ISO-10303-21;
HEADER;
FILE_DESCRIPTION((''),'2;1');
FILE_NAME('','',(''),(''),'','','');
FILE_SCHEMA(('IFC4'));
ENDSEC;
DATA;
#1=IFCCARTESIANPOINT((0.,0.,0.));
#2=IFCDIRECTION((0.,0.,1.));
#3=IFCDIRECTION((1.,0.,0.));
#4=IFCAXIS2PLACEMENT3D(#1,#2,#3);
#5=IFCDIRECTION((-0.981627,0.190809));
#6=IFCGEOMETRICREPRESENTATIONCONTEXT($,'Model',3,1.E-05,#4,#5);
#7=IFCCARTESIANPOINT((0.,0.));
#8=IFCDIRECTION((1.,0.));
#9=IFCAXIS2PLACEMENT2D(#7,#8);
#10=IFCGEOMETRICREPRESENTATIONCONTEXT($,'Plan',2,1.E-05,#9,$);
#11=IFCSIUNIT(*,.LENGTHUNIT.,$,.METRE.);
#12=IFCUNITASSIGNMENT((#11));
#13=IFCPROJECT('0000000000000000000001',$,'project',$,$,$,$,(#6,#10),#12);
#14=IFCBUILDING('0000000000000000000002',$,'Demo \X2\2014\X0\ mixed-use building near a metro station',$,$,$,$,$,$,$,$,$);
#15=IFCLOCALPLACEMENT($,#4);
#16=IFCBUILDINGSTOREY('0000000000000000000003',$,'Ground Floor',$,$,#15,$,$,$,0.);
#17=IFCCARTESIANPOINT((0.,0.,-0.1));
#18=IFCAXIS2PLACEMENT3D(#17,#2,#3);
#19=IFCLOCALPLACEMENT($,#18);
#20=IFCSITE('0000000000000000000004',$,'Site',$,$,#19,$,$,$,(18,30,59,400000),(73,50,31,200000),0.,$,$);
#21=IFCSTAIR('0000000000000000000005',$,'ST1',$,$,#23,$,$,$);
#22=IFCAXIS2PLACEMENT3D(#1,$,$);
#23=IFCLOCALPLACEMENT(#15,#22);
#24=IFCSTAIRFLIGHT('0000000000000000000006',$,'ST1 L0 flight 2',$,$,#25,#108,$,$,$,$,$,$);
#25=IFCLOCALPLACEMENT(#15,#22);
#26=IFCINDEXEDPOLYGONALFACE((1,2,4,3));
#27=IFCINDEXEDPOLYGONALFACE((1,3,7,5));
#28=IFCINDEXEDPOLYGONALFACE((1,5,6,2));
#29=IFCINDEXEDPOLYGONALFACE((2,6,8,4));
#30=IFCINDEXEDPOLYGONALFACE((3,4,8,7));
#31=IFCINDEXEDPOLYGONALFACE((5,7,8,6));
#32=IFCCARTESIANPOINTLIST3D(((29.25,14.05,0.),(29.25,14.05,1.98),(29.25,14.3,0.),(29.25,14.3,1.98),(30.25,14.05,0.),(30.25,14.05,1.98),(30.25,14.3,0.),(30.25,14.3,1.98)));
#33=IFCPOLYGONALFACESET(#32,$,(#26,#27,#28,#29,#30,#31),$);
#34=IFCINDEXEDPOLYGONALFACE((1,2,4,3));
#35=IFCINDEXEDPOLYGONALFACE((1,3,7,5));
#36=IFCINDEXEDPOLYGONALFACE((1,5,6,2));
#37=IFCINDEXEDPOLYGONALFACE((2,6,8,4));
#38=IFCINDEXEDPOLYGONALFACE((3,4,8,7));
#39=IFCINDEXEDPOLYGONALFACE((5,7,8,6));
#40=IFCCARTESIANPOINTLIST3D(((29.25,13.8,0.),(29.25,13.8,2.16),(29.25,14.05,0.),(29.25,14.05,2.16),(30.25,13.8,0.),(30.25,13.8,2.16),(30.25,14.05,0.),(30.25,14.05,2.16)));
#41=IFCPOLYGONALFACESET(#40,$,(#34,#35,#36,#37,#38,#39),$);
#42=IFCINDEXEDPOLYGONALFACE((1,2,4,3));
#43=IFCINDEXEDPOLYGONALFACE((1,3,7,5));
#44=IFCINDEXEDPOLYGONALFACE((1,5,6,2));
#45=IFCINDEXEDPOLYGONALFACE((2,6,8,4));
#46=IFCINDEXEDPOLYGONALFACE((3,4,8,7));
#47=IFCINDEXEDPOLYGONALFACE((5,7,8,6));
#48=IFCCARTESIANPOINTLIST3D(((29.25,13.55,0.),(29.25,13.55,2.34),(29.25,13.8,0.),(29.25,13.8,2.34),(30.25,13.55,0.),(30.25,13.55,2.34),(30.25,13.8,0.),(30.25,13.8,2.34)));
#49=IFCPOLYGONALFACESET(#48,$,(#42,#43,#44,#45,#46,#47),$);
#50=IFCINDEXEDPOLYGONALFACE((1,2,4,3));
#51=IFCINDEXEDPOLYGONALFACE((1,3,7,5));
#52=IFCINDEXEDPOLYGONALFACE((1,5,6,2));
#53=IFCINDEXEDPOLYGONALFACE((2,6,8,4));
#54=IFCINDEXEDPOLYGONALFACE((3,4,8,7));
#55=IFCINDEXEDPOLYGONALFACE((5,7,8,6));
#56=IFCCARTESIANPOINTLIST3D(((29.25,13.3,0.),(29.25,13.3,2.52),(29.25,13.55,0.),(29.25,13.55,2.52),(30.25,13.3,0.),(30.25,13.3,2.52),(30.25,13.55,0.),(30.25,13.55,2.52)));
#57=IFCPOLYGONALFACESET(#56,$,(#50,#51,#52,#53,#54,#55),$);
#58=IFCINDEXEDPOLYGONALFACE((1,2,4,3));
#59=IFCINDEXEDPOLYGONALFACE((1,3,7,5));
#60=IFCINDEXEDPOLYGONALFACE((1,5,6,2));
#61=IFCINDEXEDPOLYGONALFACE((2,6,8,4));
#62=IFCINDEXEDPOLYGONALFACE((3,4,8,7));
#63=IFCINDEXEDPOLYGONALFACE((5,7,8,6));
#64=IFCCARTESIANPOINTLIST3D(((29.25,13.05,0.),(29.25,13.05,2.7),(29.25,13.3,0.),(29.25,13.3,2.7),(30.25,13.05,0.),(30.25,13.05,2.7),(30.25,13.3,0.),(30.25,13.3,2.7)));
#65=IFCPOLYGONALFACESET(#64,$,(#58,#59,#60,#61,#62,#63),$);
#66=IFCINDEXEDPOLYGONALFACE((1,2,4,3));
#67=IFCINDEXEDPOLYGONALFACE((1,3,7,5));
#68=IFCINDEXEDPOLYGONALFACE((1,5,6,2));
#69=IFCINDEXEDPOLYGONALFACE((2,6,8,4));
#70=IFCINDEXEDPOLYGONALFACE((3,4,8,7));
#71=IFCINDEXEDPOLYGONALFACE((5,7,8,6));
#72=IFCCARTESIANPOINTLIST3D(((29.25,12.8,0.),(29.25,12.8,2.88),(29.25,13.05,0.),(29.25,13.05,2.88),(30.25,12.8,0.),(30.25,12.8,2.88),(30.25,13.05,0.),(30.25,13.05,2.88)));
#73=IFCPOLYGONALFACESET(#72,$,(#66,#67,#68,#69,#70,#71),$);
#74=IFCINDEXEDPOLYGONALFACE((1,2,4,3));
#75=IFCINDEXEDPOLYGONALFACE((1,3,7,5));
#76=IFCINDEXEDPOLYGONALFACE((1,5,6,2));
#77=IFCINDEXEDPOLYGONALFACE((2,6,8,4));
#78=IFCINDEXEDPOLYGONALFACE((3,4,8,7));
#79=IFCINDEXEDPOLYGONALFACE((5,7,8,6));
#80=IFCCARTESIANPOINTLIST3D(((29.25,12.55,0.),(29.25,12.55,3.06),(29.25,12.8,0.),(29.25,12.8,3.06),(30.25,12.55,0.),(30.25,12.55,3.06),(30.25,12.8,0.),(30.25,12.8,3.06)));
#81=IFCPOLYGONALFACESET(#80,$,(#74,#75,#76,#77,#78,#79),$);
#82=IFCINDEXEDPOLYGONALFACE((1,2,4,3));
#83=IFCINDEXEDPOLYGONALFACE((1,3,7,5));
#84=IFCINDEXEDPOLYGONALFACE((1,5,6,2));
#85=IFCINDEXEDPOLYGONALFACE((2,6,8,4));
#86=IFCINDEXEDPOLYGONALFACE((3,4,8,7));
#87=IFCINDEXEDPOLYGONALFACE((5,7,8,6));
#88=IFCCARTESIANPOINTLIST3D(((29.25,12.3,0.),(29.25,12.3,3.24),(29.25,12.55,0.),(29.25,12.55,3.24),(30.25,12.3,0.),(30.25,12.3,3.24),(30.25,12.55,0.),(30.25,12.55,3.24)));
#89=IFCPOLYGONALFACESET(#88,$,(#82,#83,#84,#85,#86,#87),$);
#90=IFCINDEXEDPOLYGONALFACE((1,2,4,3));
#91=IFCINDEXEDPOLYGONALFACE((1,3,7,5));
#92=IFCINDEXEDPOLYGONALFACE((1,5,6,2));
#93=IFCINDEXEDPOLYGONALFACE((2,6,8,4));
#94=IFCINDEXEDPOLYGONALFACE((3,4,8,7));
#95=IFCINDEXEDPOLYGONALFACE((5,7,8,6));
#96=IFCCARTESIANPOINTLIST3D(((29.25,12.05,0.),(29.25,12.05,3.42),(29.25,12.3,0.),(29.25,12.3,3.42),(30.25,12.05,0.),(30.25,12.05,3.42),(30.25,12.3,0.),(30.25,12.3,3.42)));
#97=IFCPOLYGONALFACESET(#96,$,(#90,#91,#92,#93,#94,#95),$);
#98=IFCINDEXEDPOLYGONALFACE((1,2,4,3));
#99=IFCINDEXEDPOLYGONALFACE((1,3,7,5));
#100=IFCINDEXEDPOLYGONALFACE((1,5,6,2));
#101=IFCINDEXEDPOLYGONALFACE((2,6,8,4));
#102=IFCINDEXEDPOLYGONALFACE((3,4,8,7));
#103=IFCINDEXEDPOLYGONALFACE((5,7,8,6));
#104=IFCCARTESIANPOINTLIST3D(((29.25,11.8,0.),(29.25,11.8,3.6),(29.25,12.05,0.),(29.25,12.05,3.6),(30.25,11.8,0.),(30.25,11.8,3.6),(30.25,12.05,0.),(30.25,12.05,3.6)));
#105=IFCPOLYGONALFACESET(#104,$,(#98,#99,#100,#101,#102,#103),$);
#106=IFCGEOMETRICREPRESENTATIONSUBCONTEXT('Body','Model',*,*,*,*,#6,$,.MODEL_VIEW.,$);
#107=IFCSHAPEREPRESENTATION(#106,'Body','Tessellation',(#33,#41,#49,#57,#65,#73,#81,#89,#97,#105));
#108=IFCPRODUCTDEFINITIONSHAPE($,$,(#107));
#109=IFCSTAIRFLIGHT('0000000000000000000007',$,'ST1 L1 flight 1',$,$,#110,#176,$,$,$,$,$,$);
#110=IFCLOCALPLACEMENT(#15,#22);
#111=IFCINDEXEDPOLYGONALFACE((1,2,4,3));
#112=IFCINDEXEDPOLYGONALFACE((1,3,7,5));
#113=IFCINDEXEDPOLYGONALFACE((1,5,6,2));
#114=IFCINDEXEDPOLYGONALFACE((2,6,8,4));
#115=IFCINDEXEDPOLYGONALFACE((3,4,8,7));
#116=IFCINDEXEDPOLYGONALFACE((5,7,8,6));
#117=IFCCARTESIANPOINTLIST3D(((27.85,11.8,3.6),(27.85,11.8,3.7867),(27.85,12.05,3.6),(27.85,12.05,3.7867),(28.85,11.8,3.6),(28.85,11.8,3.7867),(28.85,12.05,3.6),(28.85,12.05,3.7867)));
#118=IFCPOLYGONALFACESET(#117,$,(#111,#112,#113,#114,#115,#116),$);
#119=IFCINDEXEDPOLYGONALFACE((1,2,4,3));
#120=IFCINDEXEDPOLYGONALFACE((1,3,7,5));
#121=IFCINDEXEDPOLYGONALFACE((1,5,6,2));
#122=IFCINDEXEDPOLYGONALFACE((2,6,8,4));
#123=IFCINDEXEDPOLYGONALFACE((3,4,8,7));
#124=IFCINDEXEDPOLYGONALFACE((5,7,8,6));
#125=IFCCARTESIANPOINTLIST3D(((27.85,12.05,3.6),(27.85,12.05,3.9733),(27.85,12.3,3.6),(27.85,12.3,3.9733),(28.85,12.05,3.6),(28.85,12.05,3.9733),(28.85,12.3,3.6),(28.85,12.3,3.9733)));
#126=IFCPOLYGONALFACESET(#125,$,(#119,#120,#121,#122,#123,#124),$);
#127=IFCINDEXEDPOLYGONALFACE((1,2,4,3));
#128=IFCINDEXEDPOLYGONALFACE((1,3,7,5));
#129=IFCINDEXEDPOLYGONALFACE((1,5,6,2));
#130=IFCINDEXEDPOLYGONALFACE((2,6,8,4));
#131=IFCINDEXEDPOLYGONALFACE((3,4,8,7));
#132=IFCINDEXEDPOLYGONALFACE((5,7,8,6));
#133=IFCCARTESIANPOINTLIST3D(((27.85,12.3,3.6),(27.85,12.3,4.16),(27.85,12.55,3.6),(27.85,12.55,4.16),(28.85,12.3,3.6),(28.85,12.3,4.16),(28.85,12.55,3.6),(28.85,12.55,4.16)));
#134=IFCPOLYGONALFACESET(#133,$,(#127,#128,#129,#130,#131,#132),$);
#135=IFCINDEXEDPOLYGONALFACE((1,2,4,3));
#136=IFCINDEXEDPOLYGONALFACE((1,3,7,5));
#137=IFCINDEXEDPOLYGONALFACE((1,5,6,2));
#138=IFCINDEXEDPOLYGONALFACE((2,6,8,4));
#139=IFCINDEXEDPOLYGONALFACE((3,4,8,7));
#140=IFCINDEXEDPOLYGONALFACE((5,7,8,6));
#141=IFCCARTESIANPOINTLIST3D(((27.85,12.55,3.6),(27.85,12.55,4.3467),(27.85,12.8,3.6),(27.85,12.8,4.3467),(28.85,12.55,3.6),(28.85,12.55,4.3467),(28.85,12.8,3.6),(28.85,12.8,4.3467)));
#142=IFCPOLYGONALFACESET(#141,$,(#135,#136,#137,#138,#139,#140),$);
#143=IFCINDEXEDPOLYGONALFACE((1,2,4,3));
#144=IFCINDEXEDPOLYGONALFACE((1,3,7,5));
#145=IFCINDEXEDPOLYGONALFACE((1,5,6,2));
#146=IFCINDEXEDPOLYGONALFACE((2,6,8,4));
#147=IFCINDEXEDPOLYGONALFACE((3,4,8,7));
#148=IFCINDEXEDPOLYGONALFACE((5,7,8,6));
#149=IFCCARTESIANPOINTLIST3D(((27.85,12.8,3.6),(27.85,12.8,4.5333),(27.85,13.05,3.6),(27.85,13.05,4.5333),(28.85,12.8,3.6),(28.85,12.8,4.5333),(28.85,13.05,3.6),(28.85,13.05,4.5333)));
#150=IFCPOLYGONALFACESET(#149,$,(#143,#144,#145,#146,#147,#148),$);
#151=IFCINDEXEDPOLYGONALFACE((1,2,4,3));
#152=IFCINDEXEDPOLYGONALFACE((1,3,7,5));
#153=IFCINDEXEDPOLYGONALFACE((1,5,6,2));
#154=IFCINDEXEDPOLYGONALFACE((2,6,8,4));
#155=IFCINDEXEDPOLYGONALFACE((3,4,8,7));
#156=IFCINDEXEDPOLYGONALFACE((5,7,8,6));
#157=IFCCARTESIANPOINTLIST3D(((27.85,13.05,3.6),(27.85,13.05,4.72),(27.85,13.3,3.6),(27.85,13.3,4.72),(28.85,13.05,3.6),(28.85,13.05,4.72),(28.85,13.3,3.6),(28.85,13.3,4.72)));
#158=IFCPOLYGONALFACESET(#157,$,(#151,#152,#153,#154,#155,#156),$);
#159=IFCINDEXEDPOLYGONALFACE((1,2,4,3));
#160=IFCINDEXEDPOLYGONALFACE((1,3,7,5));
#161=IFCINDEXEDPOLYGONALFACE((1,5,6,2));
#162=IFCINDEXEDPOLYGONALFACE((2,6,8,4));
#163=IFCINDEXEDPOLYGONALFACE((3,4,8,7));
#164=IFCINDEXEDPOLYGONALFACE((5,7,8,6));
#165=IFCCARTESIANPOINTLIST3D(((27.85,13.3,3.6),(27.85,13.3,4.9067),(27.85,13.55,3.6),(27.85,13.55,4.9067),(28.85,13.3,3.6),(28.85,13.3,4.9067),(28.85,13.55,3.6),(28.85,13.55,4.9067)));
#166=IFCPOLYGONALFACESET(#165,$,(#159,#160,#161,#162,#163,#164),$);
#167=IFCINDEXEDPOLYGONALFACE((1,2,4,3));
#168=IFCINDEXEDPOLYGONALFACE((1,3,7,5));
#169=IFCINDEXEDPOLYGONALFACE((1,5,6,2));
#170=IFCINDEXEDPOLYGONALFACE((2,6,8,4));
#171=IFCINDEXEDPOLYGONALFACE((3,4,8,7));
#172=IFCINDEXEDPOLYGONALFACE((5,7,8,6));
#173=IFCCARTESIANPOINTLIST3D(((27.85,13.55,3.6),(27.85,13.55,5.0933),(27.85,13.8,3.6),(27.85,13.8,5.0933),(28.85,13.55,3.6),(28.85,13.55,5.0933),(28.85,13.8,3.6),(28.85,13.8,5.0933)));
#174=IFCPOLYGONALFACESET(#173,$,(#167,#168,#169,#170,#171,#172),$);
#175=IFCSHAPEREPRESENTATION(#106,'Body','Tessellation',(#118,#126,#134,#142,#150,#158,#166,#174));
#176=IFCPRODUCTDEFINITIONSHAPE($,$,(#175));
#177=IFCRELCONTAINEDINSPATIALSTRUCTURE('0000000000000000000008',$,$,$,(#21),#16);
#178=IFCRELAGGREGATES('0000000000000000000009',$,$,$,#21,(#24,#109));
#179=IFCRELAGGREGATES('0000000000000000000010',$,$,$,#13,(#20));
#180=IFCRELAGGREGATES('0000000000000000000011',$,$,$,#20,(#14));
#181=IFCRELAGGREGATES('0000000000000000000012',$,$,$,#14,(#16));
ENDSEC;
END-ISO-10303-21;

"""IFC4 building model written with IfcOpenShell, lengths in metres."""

from ifc_helpers import new_model, si_unit, direction, frame, origin_with_axes, origin_2d_with_axis, place, context, subcontext, project, spatial, line, indexed_curve, outline, extrude, element, aggregate, save


model = new_model("IFC4")

# Units and contexts
model_context = context("Model", 3, precision=1e-05, world=origin_with_axes(), true_north=direction((-0.981627, 0.190809)))
plan_context = context("Plan", 2, precision=1e-05, world=origin_2d_with_axis())
body_context = subcontext(model_context, "Body", "Model", "MODEL_VIEW")
ifc_project = project(units=[si_unit("LENGTHUNIT", "METRE")], contexts=[model_context, plan_context])

# Site, building, storey
site_placement = place(None, frame((0.0, 0.0, -0.1), z_axis=(0.0, 0.0, 1.0), x_axis=(1.0, 0.0, 0.0)))
site = spatial("IfcSite", under=ifc_project, at=site_placement, Name="Site", RefLatitude=(18, 30, 59, 400000), RefLongitude=(73, 50, 31, 200000), RefElevation=0.0)
building = spatial("IfcBuilding", under=site, Name="Demo — mixed-use building near a metro station")
storey_placement = place(None, origin_with_axes())
storey = spatial("IfcBuildingStorey", under=building, at=storey_placement, Name="Ground Floor", Elevation=0.0)

# Stair, stair flights
stair = element("IfcStair", 1, inside=storey, Name="ST1")
stair_flight_1_placement = place(None, origin_with_axes())
stair_flight_1 = element("IfcStairFlight", 2, at=stair_flight_1_placement, Name="ST1 L0 flight 2", context=body_context, shape_type="SweptSolid", body=[
    extrude(outline(indexed_curve([(29.25, 14.05), (30.25, 14.05), (30.25, 14.3), (29.25, 14.3)], segments=[line(1, 2, 3, 4, 1)])), origin_with_axes(), (0.0, 0.0, 1.0), 1.98),
    extrude(outline(indexed_curve([(29.25, 13.8), (30.25, 13.8), (30.25, 14.05), (29.25, 14.05)], segments=[line(1, 2, 3, 4, 1)])), origin_with_axes(), (0.0, 0.0, 1.0), 2.16),
    extrude(outline(indexed_curve([(29.25, 13.55), (30.25, 13.55), (30.25, 13.8), (29.25, 13.8)], segments=[line(1, 2, 3, 4, 1)])), origin_with_axes(), (0.0, 0.0, 1.0), 2.34),
    extrude(outline(indexed_curve([(29.25, 13.3), (30.25, 13.3), (30.25, 13.55), (29.25, 13.55)], segments=[line(1, 2, 3, 4, 1)])), origin_with_axes(), (0.0, 0.0, 1.0), 2.52),
    extrude(outline(indexed_curve([(29.25, 13.05), (30.25, 13.05), (30.25, 13.3), (29.25, 13.3)], segments=[line(1, 2, 3, 4, 1)])), origin_with_axes(), (0.0, 0.0, 1.0), 2.7),
    extrude(outline(indexed_curve([(29.25, 12.8), (30.25, 12.8), (30.25, 13.05), (29.25, 13.05)], segments=[line(1, 2, 3, 4, 1)])), origin_with_axes(), (0.0, 0.0, 1.0), 2.88),
    extrude(outline(indexed_curve([(29.25, 12.55), (30.25, 12.55), (30.25, 12.8), (29.25, 12.8)], segments=[line(1, 2, 3, 4, 1)])), origin_with_axes(), (0.0, 0.0, 1.0), 3.06),
    extrude(outline(indexed_curve([(29.25, 12.3), (30.25, 12.3), (30.25, 12.55), (29.25, 12.55)], segments=[line(1, 2, 3, 4, 1)])), origin_with_axes(), (0.0, 0.0, 1.0), 3.24),
    extrude(outline(indexed_curve([(29.25, 12.05), (30.25, 12.05), (30.25, 12.3), (29.25, 12.3)], segments=[line(1, 2, 3, 4, 1)])), origin_with_axes(), (0.0, 0.0, 1.0), 3.42),
    extrude(outline(indexed_curve([(29.25, 11.8), (30.25, 11.8), (30.25, 12.05), (29.25, 12.05)], segments=[line(1, 2, 3, 4, 1)])), origin_with_axes(), (0.0, 0.0, 1.0), 3.6),
])
stair_flight_2_placement = place(None, origin_with_axes())
stair_flight_2 = element("IfcStairFlight", 3, at=stair_flight_2_placement, Name="ST1 L1 flight 1", context=body_context, shape_type="SweptSolid", body=[
    extrude(outline(indexed_curve([(27.85, 11.8), (28.85, 11.8), (28.85, 12.05), (27.85, 12.05)], segments=[line(1, 2, 3, 4, 1)])), frame((0.0, 0.0, 3.6), z_axis=(0.0, 0.0, 1.0), x_axis=(1.0, 0.0, 0.0)), (0.0, 0.0, 1.0), 0.1867),
    extrude(outline(indexed_curve([(27.85, 12.05), (28.85, 12.05), (28.85, 12.3), (27.85, 12.3)], segments=[line(1, 2, 3, 4, 1)])), frame((0.0, 0.0, 3.6), z_axis=(0.0, 0.0, 1.0), x_axis=(1.0, 0.0, 0.0)), (0.0, 0.0, 1.0), 0.3733),
    extrude(outline(indexed_curve([(27.85, 12.3), (28.85, 12.3), (28.85, 12.55), (27.85, 12.55)], segments=[line(1, 2, 3, 4, 1)])), frame((0.0, 0.0, 3.6), z_axis=(0.0, 0.0, 1.0), x_axis=(1.0, 0.0, 0.0)), (0.0, 0.0, 1.0), 0.56),
    extrude(outline(indexed_curve([(27.85, 12.55), (28.85, 12.55), (28.85, 12.8), (27.85, 12.8)], segments=[line(1, 2, 3, 4, 1)])), frame((0.0, 0.0, 3.6), z_axis=(0.0, 0.0, 1.0), x_axis=(1.0, 0.0, 0.0)), (0.0, 0.0, 1.0), 0.7467),
    extrude(outline(indexed_curve([(27.85, 12.8), (28.85, 12.8), (28.85, 13.05), (27.85, 13.05)], segments=[line(1, 2, 3, 4, 1)])), frame((0.0, 0.0, 3.6), z_axis=(0.0, 0.0, 1.0), x_axis=(1.0, 0.0, 0.0)), (0.0, 0.0, 1.0), 0.9333),
    extrude(outline(indexed_curve([(27.85, 13.05), (28.85, 13.05), (28.85, 13.3), (27.85, 13.3)], segments=[line(1, 2, 3, 4, 1)])), frame((0.0, 0.0, 3.6), z_axis=(0.0, 0.0, 1.0), x_axis=(1.0, 0.0, 0.0)), (0.0, 0.0, 1.0), 1.12),
    extrude(outline(indexed_curve([(27.85, 13.3), (28.85, 13.3), (28.85, 13.55), (27.85, 13.55)], segments=[line(1, 2, 3, 4, 1)])), frame((0.0, 0.0, 3.6), z_axis=(0.0, 0.0, 1.0), x_axis=(1.0, 0.0, 0.0)), (0.0, 0.0, 1.0), 1.3067),
    extrude(outline(indexed_curve([(27.85, 13.55), (28.85, 13.55), (28.85, 13.8), (27.85, 13.8)], segments=[line(1, 2, 3, 4, 1)])), frame((0.0, 0.0, 3.6), z_axis=(0.0, 0.0, 1.0), x_axis=(1.0, 0.0, 0.0)), (0.0, 0.0, 1.0), 1.4933),
])
aggregate(stair, [stair_flight_1, stair_flight_2])

save(model, "model.ifc")
